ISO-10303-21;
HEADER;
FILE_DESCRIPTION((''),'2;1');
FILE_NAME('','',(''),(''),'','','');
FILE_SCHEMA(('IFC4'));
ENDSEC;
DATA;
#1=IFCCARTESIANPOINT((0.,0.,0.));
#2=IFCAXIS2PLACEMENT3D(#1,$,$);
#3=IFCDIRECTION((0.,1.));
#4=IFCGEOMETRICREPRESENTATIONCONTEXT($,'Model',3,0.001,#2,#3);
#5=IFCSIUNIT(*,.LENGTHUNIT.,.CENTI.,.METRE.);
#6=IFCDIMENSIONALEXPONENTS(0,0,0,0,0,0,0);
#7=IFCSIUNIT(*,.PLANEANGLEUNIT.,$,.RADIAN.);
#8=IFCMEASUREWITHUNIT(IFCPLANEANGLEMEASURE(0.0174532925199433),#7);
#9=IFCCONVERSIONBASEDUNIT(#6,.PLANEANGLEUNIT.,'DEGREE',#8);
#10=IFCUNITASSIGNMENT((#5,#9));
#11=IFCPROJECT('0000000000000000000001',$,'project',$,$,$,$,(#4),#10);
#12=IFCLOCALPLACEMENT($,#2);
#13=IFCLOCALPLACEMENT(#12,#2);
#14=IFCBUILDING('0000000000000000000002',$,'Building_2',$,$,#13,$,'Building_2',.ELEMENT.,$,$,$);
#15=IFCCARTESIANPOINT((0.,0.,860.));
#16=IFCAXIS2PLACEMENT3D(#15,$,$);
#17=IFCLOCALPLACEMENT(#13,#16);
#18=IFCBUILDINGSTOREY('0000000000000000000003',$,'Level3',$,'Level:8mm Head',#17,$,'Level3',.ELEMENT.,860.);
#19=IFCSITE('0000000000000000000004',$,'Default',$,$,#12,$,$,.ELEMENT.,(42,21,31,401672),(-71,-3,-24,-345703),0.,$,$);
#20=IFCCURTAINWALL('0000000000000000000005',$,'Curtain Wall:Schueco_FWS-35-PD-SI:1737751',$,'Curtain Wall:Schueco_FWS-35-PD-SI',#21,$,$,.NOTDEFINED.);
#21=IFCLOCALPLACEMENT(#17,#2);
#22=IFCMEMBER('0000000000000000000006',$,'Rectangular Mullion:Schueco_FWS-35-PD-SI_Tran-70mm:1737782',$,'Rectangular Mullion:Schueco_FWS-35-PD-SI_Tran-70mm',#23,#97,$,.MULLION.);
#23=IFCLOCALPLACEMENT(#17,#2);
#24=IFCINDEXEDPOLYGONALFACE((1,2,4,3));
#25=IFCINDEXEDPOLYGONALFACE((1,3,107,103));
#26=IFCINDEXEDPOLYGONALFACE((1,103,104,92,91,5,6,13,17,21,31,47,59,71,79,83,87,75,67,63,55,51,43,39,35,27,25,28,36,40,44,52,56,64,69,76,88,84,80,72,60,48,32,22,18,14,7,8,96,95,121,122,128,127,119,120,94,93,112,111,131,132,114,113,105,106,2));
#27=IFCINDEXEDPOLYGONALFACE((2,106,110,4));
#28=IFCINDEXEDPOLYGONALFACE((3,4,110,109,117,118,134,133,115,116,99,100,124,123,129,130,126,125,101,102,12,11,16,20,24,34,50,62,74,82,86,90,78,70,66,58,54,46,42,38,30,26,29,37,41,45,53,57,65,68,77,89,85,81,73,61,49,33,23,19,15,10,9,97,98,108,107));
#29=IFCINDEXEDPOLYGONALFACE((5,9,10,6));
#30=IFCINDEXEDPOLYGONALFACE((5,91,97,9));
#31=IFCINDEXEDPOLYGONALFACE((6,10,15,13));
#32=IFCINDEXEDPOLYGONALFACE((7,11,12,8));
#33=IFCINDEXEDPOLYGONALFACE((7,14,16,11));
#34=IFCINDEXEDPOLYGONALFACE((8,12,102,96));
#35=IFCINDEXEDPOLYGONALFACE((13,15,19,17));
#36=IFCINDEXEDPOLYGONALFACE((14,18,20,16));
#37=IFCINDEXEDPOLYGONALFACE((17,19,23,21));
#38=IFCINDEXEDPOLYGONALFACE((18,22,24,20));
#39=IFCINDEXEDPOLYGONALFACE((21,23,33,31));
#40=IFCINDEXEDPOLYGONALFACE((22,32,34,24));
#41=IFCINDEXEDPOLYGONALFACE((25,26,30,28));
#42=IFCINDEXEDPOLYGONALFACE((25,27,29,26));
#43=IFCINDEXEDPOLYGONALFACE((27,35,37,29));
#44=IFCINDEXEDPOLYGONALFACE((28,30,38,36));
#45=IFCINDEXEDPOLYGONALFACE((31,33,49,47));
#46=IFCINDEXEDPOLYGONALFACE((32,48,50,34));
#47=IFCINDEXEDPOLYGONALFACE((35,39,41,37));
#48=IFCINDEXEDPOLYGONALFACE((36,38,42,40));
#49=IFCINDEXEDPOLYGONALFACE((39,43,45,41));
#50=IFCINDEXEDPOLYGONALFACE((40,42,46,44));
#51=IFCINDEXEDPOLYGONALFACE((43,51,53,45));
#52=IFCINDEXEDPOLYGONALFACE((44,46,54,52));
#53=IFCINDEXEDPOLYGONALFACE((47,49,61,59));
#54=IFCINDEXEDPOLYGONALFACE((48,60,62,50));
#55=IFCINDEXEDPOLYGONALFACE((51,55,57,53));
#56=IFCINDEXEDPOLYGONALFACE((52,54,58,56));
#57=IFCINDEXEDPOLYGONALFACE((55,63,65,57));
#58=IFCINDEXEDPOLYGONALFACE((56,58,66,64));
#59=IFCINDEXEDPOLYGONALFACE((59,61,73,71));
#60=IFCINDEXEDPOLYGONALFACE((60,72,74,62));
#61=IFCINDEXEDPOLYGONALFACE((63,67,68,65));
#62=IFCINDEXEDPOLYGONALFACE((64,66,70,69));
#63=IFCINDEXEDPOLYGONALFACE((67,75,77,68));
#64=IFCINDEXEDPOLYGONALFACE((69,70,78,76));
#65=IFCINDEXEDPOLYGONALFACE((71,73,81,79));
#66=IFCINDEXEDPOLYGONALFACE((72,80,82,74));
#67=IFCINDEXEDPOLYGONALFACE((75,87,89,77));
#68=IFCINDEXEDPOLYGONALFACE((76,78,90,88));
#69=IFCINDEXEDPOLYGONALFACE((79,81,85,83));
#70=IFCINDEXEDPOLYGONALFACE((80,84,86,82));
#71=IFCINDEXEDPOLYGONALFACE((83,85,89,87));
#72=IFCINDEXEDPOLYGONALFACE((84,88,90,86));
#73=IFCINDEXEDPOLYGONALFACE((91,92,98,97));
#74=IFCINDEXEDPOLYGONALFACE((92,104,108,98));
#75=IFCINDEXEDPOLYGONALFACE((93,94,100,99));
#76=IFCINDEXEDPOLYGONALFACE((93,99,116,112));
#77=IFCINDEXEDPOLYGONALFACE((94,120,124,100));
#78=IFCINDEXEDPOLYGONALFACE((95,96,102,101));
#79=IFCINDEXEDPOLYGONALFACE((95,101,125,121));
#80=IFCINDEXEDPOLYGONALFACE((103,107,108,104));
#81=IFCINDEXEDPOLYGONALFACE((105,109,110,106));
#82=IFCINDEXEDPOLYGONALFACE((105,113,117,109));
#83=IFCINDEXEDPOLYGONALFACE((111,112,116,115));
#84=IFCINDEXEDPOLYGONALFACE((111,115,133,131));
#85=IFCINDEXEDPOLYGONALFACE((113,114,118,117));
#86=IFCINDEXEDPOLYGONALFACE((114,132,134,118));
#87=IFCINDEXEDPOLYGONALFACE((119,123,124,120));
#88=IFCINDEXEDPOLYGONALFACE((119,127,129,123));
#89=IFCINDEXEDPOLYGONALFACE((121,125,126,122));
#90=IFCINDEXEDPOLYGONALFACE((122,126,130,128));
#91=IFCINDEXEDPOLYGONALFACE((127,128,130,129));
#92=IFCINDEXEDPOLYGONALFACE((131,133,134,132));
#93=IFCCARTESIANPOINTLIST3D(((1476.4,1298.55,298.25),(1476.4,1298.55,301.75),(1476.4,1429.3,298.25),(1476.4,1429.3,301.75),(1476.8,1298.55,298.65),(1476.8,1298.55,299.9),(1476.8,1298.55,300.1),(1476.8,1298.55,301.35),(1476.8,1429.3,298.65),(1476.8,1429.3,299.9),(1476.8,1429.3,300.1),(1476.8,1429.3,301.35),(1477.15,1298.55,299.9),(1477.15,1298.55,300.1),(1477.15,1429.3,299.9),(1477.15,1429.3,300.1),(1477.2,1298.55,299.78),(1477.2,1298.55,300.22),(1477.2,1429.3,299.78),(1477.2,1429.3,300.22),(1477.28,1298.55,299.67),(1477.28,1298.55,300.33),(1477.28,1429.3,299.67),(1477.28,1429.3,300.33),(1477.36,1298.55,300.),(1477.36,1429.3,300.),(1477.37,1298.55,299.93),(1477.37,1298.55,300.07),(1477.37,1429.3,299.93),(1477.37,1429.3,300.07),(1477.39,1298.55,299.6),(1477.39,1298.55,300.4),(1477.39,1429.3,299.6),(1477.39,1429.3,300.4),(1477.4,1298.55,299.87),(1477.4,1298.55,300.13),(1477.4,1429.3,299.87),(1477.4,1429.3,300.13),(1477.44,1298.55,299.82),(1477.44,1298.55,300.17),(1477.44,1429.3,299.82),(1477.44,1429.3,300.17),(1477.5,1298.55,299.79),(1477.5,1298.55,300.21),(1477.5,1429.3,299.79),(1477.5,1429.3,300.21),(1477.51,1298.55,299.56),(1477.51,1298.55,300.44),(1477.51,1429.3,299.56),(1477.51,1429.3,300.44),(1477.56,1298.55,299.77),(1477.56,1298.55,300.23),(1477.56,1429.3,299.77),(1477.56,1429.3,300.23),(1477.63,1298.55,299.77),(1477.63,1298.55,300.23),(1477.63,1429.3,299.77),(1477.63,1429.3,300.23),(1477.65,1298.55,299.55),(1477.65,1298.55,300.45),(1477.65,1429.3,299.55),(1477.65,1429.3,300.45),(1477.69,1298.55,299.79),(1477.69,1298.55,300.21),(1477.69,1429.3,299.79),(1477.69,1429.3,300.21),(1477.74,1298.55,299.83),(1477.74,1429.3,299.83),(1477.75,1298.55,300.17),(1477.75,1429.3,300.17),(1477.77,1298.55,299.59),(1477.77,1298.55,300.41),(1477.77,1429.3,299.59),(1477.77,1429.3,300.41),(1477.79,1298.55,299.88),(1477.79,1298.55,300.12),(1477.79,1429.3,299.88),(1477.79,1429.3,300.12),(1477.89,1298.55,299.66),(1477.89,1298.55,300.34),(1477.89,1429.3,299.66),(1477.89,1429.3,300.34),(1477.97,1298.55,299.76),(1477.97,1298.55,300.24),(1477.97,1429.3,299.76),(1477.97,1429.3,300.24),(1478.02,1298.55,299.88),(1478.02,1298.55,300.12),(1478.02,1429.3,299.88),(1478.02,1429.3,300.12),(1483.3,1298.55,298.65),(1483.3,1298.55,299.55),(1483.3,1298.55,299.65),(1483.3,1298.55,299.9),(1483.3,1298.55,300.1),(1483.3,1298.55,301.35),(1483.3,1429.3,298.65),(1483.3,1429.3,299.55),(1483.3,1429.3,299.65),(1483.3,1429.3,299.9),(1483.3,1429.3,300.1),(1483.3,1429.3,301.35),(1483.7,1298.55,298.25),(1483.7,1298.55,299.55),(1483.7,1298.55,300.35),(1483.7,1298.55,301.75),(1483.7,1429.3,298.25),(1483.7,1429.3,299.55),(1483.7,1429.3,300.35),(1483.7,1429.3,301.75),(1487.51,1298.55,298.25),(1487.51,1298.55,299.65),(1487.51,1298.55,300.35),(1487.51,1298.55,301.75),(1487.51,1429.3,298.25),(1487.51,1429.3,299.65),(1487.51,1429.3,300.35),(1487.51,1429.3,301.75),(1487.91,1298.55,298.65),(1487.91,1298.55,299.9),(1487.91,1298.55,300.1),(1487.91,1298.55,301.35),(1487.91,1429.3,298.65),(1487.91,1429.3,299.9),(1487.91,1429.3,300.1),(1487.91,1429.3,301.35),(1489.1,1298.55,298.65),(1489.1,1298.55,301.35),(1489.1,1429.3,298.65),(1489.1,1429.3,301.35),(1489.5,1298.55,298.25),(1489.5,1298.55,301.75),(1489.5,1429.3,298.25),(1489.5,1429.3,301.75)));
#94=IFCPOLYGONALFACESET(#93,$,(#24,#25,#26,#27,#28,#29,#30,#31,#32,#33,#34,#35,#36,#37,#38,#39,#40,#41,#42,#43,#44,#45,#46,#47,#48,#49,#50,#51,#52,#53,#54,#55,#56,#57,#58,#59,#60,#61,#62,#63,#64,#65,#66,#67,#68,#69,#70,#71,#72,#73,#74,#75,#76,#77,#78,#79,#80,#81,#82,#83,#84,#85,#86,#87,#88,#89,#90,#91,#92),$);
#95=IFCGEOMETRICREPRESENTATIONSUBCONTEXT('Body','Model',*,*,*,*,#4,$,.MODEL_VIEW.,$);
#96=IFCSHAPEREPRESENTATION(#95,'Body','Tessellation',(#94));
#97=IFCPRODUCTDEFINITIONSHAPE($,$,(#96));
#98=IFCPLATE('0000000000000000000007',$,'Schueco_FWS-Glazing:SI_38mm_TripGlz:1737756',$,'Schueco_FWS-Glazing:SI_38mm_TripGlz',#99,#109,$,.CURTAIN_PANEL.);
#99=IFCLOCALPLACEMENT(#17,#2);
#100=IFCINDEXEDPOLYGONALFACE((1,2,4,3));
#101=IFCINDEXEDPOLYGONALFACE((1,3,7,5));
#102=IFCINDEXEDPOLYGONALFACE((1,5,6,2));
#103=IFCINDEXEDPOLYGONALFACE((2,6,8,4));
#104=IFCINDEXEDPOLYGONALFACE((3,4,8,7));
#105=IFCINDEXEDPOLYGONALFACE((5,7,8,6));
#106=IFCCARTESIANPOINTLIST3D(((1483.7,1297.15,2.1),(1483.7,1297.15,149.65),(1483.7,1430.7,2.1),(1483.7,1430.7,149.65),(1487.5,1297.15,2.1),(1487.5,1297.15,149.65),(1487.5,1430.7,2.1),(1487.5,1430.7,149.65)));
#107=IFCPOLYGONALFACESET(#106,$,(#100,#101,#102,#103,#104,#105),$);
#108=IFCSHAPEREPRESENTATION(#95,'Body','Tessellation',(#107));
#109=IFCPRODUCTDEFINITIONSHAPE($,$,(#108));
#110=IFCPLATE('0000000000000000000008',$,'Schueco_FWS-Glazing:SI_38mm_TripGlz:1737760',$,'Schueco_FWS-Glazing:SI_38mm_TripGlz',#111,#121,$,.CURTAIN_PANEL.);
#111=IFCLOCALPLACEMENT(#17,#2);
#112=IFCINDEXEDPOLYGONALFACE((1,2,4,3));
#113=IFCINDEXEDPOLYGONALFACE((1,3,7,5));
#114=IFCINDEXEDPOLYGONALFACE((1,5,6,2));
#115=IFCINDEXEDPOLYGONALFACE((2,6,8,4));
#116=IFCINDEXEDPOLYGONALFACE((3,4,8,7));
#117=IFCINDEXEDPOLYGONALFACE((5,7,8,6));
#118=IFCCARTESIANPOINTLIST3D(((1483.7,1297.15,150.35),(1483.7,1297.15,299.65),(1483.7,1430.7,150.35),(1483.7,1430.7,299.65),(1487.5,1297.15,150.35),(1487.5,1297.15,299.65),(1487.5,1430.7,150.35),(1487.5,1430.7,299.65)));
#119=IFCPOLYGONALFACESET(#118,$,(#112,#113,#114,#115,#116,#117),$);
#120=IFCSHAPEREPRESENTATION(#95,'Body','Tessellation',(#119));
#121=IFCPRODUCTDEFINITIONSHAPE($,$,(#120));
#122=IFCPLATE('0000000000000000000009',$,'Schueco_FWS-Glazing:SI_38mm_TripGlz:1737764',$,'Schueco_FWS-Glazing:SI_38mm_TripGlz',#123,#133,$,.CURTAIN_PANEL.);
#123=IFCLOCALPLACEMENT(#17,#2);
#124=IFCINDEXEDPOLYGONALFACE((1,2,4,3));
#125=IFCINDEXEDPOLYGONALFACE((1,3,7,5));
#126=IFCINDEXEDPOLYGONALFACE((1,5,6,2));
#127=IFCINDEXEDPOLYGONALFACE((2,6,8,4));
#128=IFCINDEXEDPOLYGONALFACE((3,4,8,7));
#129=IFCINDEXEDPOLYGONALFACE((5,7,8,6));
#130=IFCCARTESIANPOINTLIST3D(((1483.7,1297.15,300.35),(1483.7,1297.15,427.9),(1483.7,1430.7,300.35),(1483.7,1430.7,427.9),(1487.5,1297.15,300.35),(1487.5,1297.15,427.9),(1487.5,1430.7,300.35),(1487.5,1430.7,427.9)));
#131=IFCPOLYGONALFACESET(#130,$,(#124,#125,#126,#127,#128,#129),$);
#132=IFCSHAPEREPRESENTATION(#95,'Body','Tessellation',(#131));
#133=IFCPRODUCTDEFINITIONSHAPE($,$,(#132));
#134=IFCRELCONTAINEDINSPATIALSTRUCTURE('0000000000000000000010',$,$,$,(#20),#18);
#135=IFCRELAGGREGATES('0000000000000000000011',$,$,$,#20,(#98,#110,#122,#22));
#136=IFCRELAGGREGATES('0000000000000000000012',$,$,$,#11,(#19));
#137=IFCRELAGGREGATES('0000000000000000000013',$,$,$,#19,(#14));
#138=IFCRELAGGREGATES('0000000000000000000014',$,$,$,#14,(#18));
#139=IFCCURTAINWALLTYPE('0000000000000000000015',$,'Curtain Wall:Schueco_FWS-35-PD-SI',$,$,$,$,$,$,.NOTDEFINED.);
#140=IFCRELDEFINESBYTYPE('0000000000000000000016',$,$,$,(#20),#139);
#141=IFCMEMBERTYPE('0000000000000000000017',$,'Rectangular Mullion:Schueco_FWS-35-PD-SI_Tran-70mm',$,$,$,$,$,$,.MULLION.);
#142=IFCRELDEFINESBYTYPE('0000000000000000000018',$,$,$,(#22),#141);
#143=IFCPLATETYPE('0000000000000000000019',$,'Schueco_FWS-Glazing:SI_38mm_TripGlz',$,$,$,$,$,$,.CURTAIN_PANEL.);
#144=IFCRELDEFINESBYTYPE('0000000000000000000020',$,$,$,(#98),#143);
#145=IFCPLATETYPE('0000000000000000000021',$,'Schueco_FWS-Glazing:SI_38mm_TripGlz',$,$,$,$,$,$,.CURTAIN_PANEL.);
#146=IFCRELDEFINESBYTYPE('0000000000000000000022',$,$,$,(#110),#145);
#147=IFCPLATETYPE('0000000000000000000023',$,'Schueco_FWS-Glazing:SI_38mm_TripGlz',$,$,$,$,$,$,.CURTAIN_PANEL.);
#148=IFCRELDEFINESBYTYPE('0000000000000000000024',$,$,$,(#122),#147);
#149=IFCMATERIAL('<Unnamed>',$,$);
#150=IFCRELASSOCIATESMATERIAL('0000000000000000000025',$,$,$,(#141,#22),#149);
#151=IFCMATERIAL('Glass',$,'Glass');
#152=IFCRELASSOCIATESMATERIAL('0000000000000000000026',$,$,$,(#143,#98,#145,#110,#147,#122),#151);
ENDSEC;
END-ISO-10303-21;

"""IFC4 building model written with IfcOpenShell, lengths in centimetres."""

from ifc_helpers import new_model, entity, si_unit, converted_unit, direction, frame, origin, place, context, subcontext, project, spatial, line, arc, indexed_curve, outline, extrude, source, transform, mapped, material, type_object, type_shapes, element, aggregate, save


model = new_model("IFC4")

# Units and contexts
model_context = context("Model", 3, precision=0.001, world=origin(), true_north=direction((0.0, 1.0)))
body_context = subcontext(model_context, "Body", "Model", "MODEL_VIEW")
ifc_project = project(units=[si_unit("LENGTHUNIT", "METRE", prefix="CENTI"), converted_unit("PLANEANGLEUNIT", "DEGREE", entity("IfcPlaneAngleMeasure", 0.0174532925199433), si_unit("PLANEANGLEUNIT", "RADIAN"), dimensions=[0, 0, 0, 0, 0, 0, 0])], contexts=[model_context])

# Site, building, storey
site_placement = place(None, origin())
site = spatial("IfcSite", under=ifc_project, at=site_placement, Name="Default", CompositionType="ELEMENT", RefLatitude=(42, 21, 31, 401672), RefLongitude=(-71, -3, -24, -345703), RefElevation=0.0)
building_placement = place(site_placement, origin())
building = spatial("IfcBuilding", under=site, at=building_placement, Name="Building_2", LongName="Building_2", CompositionType="ELEMENT")
storey_placement = place(building_placement, frame((0.0, 0.0, 860.0)))
storey = spatial("IfcBuildingStorey", under=building, at=storey_placement, Name="Level3", ObjectType="Level:8mm Head", LongName="Level3", CompositionType="ELEMENT", Elevation=860.0)

# Curtain wall, member, plates
curtain_wall_type = type_object("IfcCurtainWallType", Name="Curtain Wall:Schueco_FWS-35-PD-SI", PredefinedType="NOTDEFINED")
curtain_wall_placement = place(storey_placement, frame((0.0, 0.0, -860.0)))
curtain_wall = element("IfcCurtainWall", 1, at=curtain_wall_placement, inside=storey, type_object=curtain_wall_type, Name="Curtain Wall:Schueco_FWS-35-PD-SI:1737751", ObjectType="Curtain Wall:Schueco_FWS-35-PD-SI", PredefinedType="NOTDEFINED")
ifc_material_1 = material(Name="<Unnamed>")
member_type_1 = type_object("IfcMemberType", Name="Rectangular Mullion:Schueco_FWS-35-PD-SI_Tran-70mm", PredefinedType="MULLION", material=ifc_material_1)
shared_shape_1 = source(origin(), body_context, "Body", "SweptSolid", [
    extrude(outline(indexed_curve([(-1.78, -6.52), (1.72, -6.52), (1.72, 0.78), (0.42, 0.78), (0.42, 0.38), (1.32, 0.38), (1.32, -6.12), (0.07, -6.12), (0.07, -5.77), (0.42, -5.34), (0.09, -4.9), (0.09, -5.14), (-0.03, -5.56), (-0.15, -5.14), (-0.15, -4.9), (-0.48, -5.34), (-0.13, -5.77), (-0.13, -6.12), (-1.38, -6.12), (-1.38, 0.38), (-0.13, 0.38), (-0.13, 4.99), (-1.38, 4.99), (-1.38, 6.18), (1.32, 6.18), (1.32, 4.99), (0.07, 4.99), (0.07, 0.38), (0.32, 0.38), (0.32, 4.59), (1.72, 4.59), (1.72, 6.58), (-1.78, 6.58), (-1.78, 4.59), (-0.38, 4.59), (-0.38, 0.78), (-1.78, 0.78)], segments=[line(1, 2, 3, 4, 5, 6, 7, 8, 9), arc(9, 10, 11), line(11, 12), arc(12, 13, 14), line(14, 15), arc(15, 16, 17), line(17, 18, 19, 20, 21, 22, 23, 24, 25, 26, 27, 28, 29, 30, 31, 32, 33, 34, 35, 36, 37, 1)], self_intersect=False)), frame((-0.03, 4.58, -130.75), z_axis=(0.0, 0.0, 1.0), x_axis=(-1.0, 0.0, 0.0)), (0.0, 0.0, 1.0), 130.75),
])
type_shapes(member_type_1, [shared_shape_1])
member_1_placement = place(curtain_wall_placement, frame((1487.5, 1298.55, 1160.0), z_axis=(0.0, -1.0, 0.0), x_axis=(0.0, 0.0, 1.0)))
member_1 = element("IfcMember", 2, at=member_1_placement, type_object=member_type_1, material=ifc_material_1, Name="Rectangular Mullion:Schueco_FWS-35-PD-SI_Tran-70mm:1737782", ObjectType="Rectangular Mullion:Schueco_FWS-35-PD-SI_Tran-70mm", PredefinedType="MULLION", context=body_context, shape_type="MappedRepresentation", body=[
    mapped(shared_shape_1, transform((0.0, 0.0, 0.0), scale=1.0)),
])
ifc_material_2 = material(Name="Glass", Category="Glass")
plate_type_1 = type_object("IfcPlateType", Name="Schueco_FWS-Glazing:SI_38mm_TripGlz", PredefinedType="CURTAIN_PANEL", material=ifc_material_2)
shared_shape_2 = source(origin(), body_context, "Body", "SweptSolid", [
    extrude(outline(indexed_curve([(-1.9, -66.78), (1.9, -66.78), (1.9, 66.78), (-1.9, 66.78), (-1.9, -66.78)], self_intersect=False)), frame((0.0, -1.9, 0.0), z_axis=(0.0, 0.0, 1.0), x_axis=(0.0, 1.0, 0.0)), (0.0, 0.0, 1.0), 147.55),
])
type_shapes(plate_type_1, [shared_shape_2])
plate_1_placement = place(curtain_wall_placement, frame((1487.5, 1363.92, 862.1), z_axis=(0.0, 0.0, 1.0), x_axis=(0.0, -1.0, 0.0)))
plate_1 = element("IfcPlate", 3, at=plate_1_placement, type_object=plate_type_1, material=ifc_material_2, Name="Schueco_FWS-Glazing:SI_38mm_TripGlz:1737756", ObjectType="Schueco_FWS-Glazing:SI_38mm_TripGlz", PredefinedType="CURTAIN_PANEL", context=body_context, shape_type="MappedRepresentation", body=[
    mapped(shared_shape_2, transform((0.0, 0.0, 0.0), scale=1.0)),
])
plate_type_2 = type_object("IfcPlateType", Name="Schueco_FWS-Glazing:SI_38mm_TripGlz", PredefinedType="CURTAIN_PANEL", material=ifc_material_2)
shared_shape_3 = source(origin(), body_context, "Body", "SweptSolid", [
    extrude(outline(indexed_curve([(-1.9, -66.78), (1.9, -66.78), (1.9, 66.78), (-1.9, 66.78), (-1.9, -66.78)], self_intersect=False)), frame((0.0, -1.9, 0.0), z_axis=(0.0, 0.0, 1.0), x_axis=(0.0, 1.0, 0.0)), (0.0, 0.0, 1.0), 149.3),
])
type_shapes(plate_type_2, [shared_shape_3])
plate_2_placement = place(curtain_wall_placement, frame((1487.5, 1363.92, 1010.35), z_axis=(0.0, 0.0, 1.0), x_axis=(0.0, -1.0, 0.0)))
plate_2 = element("IfcPlate", 4, at=plate_2_placement, type_object=plate_type_2, material=ifc_material_2, Name="Schueco_FWS-Glazing:SI_38mm_TripGlz:1737760", ObjectType="Schueco_FWS-Glazing:SI_38mm_TripGlz", PredefinedType="CURTAIN_PANEL", context=body_context, shape_type="MappedRepresentation", body=[
    mapped(shared_shape_3, transform((0.0, 0.0, 0.0), scale=1.0)),
])
plate_type_3 = type_object("IfcPlateType", Name="Schueco_FWS-Glazing:SI_38mm_TripGlz", PredefinedType="CURTAIN_PANEL", material=ifc_material_2)
shared_shape_4 = source(origin(), body_context, "Body", "SweptSolid", [
    extrude(outline(indexed_curve([(-1.9, -66.78), (1.9, -66.78), (1.9, 66.78), (-1.9, 66.78), (-1.9, -66.78)], self_intersect=False)), frame((0.0, -1.9, 0.0), z_axis=(0.0, 0.0, 1.0), x_axis=(0.0, 1.0, 0.0)), (0.0, 0.0, 1.0), 127.55),
])
type_shapes(plate_type_3, [shared_shape_4])
plate_3_placement = place(curtain_wall_placement, frame((1487.5, 1363.92, 1160.35), z_axis=(0.0, 0.0, 1.0), x_axis=(0.0, -1.0, 0.0)))
plate_3 = element("IfcPlate", 5, at=plate_3_placement, type_object=plate_type_3, material=ifc_material_2, Name="Schueco_FWS-Glazing:SI_38mm_TripGlz:1737764", ObjectType="Schueco_FWS-Glazing:SI_38mm_TripGlz", PredefinedType="CURTAIN_PANEL", context=body_context, shape_type="MappedRepresentation", body=[
    mapped(shared_shape_4, transform((0.0, 0.0, 0.0), scale=1.0)),
])
aggregate(curtain_wall, [plate_1, plate_2, plate_3, member_1])

save(model, "model.ifc")
